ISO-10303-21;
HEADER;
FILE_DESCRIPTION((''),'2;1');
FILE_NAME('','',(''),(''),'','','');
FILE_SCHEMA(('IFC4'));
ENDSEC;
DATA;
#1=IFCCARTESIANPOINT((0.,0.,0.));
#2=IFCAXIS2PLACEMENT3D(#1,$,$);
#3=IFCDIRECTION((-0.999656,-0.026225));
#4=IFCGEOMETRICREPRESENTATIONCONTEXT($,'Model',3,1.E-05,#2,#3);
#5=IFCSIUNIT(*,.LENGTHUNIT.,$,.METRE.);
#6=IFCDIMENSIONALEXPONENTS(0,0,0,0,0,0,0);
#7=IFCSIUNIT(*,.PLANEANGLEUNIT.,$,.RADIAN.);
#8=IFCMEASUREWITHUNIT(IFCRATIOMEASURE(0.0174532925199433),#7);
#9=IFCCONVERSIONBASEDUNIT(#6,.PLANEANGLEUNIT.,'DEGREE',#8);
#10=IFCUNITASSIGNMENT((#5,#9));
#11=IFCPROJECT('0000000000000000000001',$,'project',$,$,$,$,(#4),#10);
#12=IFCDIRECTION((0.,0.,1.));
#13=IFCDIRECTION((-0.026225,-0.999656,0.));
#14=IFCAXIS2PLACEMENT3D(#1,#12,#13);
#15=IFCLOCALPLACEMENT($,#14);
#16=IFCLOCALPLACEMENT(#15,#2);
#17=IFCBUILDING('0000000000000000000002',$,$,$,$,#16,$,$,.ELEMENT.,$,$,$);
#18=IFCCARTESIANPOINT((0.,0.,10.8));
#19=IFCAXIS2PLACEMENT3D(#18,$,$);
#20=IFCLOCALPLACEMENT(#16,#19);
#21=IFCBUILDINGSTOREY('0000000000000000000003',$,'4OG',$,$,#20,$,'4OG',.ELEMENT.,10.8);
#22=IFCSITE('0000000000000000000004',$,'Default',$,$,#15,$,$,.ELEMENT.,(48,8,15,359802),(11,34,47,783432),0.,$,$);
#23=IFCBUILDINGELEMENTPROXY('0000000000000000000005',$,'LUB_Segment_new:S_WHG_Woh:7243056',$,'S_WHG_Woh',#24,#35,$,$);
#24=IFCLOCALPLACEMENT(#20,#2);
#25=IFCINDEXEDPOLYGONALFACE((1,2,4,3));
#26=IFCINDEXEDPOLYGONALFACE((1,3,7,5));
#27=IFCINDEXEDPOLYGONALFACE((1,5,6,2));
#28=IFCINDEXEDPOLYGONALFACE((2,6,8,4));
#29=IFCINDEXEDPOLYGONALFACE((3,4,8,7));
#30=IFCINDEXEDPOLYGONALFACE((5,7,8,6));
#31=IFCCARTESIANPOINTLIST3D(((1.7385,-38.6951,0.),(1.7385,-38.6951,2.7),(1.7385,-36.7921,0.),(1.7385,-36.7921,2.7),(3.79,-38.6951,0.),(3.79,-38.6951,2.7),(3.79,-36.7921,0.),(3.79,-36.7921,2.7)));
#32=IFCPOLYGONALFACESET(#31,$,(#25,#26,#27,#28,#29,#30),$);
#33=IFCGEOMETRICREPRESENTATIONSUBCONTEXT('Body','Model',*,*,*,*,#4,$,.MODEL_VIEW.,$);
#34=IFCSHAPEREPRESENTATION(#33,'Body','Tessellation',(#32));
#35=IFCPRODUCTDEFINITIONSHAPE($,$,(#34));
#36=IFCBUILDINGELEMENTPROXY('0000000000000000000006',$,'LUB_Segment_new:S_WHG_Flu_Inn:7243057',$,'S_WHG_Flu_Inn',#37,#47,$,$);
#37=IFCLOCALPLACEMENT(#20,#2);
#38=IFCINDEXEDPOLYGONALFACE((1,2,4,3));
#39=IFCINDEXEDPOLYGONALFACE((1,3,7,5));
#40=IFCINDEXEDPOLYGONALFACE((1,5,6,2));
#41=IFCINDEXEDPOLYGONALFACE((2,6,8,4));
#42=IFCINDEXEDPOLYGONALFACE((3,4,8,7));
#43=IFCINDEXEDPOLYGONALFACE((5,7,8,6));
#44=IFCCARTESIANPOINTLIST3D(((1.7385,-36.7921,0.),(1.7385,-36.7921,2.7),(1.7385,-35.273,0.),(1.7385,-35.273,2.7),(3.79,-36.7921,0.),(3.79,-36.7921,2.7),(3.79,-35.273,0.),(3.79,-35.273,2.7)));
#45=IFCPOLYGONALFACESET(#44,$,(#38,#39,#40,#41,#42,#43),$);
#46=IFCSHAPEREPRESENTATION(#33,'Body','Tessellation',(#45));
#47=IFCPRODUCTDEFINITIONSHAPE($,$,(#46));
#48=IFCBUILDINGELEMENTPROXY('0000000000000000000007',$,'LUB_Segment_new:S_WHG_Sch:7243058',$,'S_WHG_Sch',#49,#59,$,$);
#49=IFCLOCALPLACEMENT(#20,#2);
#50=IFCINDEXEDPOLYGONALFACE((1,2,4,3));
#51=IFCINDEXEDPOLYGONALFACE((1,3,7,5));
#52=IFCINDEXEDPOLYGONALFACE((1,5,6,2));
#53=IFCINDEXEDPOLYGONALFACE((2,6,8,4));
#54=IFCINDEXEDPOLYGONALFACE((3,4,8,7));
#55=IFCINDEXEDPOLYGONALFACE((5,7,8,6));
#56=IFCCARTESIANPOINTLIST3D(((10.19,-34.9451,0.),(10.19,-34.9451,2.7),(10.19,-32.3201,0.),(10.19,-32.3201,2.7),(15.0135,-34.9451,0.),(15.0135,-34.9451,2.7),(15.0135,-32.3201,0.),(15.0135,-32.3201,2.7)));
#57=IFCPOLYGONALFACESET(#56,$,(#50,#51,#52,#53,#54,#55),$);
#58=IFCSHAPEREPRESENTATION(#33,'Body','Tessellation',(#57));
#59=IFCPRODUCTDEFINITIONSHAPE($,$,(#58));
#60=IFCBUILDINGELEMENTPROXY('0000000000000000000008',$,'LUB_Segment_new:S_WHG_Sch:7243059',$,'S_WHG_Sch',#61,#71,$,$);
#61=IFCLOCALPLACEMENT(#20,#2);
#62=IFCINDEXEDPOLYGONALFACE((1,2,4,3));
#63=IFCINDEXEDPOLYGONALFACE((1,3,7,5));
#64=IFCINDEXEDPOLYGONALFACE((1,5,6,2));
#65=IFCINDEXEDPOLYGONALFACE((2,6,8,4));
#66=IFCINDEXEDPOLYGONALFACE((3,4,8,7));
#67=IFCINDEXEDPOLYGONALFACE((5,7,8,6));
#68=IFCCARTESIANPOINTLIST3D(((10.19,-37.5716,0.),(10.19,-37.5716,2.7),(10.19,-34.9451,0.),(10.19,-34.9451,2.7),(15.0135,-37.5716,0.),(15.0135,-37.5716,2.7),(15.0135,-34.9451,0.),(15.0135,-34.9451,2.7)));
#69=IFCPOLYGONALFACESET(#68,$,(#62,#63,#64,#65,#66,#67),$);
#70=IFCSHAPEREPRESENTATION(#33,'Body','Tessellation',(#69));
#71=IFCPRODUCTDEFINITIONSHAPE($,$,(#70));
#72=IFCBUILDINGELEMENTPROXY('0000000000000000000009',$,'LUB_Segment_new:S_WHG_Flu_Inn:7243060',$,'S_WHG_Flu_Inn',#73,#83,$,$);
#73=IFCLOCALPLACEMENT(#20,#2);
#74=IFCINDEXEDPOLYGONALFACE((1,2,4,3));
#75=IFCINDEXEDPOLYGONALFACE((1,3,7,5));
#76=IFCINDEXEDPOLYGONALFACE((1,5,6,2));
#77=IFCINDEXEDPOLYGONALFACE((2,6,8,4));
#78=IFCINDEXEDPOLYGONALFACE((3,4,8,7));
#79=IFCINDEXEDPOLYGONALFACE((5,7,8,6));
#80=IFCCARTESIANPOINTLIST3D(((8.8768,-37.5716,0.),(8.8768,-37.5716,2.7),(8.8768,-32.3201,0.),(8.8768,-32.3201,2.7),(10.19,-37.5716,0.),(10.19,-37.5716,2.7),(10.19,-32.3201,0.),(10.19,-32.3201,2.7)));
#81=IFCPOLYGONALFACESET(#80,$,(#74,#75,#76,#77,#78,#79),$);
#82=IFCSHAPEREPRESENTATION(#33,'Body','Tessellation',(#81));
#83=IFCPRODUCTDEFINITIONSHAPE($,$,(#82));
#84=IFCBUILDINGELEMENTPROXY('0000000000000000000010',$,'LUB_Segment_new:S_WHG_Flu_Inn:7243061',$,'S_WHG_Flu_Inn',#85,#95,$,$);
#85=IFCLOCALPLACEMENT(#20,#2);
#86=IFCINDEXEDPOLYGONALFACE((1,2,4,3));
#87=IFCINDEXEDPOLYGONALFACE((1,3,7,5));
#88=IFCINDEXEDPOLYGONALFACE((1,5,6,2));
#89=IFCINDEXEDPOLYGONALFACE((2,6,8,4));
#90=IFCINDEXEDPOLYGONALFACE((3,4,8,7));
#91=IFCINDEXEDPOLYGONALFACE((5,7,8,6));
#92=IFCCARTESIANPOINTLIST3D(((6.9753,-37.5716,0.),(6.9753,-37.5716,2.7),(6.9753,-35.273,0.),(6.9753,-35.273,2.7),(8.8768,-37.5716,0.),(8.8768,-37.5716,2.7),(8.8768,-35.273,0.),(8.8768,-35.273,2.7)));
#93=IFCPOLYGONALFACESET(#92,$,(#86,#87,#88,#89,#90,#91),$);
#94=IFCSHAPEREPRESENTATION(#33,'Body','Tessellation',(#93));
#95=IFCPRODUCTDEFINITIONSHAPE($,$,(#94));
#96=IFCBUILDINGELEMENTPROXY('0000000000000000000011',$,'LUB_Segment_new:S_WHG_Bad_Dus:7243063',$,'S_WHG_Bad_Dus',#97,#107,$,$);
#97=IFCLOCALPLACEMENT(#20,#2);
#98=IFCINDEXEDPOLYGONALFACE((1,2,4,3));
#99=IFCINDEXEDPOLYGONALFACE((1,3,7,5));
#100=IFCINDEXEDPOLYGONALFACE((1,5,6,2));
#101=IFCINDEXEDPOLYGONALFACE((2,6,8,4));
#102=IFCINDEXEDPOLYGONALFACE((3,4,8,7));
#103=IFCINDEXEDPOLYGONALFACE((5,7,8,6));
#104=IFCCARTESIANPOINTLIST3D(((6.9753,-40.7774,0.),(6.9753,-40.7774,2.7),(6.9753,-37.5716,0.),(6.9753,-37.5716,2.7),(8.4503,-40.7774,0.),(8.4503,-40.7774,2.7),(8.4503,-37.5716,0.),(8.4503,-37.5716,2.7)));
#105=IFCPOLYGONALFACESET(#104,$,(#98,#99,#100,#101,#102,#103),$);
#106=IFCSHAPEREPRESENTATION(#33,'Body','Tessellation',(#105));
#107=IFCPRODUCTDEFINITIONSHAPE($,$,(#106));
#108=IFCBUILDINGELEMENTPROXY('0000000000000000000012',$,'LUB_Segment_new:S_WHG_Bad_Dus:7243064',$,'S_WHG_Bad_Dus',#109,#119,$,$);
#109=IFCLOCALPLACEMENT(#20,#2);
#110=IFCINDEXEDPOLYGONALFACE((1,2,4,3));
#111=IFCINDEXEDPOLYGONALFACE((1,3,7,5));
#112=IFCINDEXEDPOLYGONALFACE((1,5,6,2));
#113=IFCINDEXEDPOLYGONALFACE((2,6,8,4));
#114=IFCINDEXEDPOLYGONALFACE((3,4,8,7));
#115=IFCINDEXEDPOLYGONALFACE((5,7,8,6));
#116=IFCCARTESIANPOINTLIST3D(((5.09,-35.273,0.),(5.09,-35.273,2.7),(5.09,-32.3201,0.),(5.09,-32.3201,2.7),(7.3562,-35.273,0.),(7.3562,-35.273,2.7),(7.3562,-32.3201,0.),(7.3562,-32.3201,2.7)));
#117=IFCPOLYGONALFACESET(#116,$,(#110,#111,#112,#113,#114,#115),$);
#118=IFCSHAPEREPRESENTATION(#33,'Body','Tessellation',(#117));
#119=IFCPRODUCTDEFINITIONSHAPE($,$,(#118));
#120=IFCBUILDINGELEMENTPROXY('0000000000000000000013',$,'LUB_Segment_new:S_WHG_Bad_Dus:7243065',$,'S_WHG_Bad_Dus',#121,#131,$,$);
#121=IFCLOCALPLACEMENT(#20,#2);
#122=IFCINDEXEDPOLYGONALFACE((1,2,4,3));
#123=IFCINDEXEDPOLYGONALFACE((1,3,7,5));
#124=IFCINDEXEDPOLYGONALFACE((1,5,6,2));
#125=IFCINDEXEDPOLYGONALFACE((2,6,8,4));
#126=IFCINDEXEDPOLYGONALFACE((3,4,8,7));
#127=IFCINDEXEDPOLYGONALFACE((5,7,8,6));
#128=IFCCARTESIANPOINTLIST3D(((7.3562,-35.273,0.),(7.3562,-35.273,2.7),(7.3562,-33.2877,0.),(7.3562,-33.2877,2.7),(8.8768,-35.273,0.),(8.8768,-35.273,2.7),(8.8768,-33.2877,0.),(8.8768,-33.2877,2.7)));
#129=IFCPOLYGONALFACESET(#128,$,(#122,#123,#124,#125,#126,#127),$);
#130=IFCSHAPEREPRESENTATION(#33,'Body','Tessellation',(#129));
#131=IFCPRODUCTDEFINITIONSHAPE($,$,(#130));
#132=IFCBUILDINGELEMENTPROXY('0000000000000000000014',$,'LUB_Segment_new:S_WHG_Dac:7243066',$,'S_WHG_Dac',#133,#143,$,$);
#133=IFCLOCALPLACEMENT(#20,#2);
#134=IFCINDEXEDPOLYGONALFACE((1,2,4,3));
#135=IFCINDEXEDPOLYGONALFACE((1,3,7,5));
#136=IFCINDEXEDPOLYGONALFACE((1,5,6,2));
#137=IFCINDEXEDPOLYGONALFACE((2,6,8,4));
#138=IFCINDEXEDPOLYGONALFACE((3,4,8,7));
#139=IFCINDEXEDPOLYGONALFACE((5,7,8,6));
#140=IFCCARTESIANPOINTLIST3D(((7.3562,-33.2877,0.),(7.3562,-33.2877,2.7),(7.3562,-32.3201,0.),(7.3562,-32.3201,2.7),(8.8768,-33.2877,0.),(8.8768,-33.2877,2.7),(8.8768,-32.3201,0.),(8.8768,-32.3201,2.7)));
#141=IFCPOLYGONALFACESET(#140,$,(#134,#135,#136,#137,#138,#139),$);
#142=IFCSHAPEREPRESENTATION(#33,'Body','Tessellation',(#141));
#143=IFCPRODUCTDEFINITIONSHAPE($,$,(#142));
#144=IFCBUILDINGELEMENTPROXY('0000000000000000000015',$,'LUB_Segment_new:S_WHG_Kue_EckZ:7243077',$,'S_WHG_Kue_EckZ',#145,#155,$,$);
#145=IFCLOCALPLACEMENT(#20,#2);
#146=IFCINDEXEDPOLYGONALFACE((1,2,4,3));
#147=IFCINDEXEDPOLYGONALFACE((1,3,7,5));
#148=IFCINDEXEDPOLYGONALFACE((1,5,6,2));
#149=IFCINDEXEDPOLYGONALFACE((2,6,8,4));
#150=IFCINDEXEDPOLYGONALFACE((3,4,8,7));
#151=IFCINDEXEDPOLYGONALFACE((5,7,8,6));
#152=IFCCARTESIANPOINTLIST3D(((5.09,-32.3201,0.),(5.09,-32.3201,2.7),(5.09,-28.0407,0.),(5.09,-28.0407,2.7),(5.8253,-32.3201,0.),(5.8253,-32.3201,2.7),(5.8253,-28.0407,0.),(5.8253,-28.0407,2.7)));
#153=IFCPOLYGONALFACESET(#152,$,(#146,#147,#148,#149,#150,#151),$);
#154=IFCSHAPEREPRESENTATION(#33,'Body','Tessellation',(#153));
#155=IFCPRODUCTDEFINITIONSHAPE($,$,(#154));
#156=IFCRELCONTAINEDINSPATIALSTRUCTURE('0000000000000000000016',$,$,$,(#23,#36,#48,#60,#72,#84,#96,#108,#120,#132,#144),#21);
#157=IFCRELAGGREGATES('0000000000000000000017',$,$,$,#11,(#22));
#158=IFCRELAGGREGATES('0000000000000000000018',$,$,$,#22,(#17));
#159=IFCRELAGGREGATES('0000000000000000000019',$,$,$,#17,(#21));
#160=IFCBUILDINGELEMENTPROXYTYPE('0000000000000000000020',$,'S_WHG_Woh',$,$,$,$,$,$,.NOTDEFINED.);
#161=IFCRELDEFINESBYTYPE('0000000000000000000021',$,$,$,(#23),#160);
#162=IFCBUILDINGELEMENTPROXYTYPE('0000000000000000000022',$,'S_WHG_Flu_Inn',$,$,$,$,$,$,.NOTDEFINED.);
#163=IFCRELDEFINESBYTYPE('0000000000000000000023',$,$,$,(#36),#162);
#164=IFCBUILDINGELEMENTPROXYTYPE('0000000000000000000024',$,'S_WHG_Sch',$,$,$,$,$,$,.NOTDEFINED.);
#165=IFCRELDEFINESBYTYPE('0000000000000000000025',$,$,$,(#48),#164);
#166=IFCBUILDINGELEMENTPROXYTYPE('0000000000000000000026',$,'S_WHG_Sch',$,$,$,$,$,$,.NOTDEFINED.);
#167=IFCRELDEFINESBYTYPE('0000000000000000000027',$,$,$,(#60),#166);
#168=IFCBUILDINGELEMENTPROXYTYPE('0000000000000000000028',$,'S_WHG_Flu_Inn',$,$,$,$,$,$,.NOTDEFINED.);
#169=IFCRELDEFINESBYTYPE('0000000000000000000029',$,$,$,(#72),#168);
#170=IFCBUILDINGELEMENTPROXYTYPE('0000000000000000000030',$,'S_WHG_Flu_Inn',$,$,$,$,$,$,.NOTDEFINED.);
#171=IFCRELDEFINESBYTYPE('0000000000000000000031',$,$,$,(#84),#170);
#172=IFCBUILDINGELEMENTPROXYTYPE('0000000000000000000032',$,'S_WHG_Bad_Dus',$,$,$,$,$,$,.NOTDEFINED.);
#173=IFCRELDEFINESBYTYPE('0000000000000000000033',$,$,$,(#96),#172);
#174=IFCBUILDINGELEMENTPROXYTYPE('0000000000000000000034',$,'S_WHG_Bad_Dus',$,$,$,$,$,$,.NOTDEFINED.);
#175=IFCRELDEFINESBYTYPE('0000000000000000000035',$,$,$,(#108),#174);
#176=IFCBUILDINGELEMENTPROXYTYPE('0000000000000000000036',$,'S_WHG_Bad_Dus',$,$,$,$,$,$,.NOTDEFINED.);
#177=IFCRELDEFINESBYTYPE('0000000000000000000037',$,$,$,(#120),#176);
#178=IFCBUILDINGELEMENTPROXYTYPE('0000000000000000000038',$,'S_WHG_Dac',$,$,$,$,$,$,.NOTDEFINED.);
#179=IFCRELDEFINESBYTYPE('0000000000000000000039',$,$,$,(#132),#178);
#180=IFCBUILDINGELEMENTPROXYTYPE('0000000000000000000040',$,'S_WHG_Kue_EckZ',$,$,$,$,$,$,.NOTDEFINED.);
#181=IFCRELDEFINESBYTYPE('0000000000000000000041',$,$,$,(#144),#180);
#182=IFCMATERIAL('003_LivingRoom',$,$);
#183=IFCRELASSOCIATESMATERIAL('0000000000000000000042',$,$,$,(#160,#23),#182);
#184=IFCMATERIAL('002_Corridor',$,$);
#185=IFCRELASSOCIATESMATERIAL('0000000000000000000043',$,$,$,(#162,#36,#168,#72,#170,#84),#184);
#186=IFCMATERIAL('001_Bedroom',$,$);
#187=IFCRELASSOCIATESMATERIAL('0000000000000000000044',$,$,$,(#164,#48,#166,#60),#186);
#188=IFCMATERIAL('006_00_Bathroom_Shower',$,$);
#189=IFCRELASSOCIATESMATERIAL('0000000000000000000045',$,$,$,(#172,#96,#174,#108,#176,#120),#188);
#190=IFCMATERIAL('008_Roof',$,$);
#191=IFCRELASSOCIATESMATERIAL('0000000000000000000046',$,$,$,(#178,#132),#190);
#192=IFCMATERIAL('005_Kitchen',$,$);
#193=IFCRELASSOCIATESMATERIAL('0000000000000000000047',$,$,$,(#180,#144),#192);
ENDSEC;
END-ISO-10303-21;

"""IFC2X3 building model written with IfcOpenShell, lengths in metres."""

from ifc_helpers import new_model, entity, si_unit, converted_unit, direction, frame, frame_2d, origin, origin_2d_with_axis, place, context, subcontext, project, spatial, rectangle, extrude, source, transform, mapped, material, type_object, type_shapes, element, save


model = new_model("IFC2X3")

# Units and contexts
model_context = context("Model", 3, precision=1e-05, world=origin(), true_north=direction((-0.999656, -0.026225)))
body_context = subcontext(model_context, "Body", "Model", "MODEL_VIEW")
ifc_project = project(units=[si_unit("LENGTHUNIT", "METRE"), converted_unit("PLANEANGLEUNIT", "DEGREE", entity("IfcRatioMeasure", 0.0174532925199433), si_unit("PLANEANGLEUNIT", "RADIAN"), dimensions=[0, 0, 0, 0, 0, 0, 0])], contexts=[model_context])

# Site, building, storey
site_placement = place(None, frame((0.0, 0.0, 0.0), z_axis=(0.0, 0.0, 1.0), x_axis=(-0.026225, -0.999656, 0.0)))
site = spatial("IfcSite", under=ifc_project, at=site_placement, Name="Default", CompositionType="ELEMENT", RefLatitude=(48, 8, 15, 359802), RefLongitude=(11, 34, 47, 783432), RefElevation=0.0)
building_placement = place(site_placement, origin())
building = spatial("IfcBuilding", under=site, at=building_placement, CompositionType="ELEMENT")
storey_placement = place(building_placement, frame((0.0, 0.0, 10.8)))
storey = spatial("IfcBuildingStorey", under=building, at=storey_placement, Name="4OG", LongName="4OG", CompositionType="ELEMENT", Elevation=10.8)

# Building element proxies
ifc_material_1 = material(Name="001_Bedroom")
ifc_material_2 = material(Name="002_Corridor")
ifc_material_3 = material(Name="006_00_Bathroom_Shower")
ifc_material_4 = material(Name="005_Kitchen")
ifc_material_5 = material(Name="003_LivingRoom")
building_element_proxy_type_1 = type_object("IfcBuildingElementProxyType", Name="S_WHG_Woh", PredefinedType="NOTDEFINED", material=ifc_material_5)
shared_shape_1 = source(origin(), body_context, "Body", "SweptSolid", [
    extrude(rectangle(XDim=2.0515, YDim=1.9029, at=origin_2d_with_axis()), frame((0.0, 0.0, 0.0), z_axis=(0.0, 0.0, 1.0), x_axis=(-1.0, 0.0, 0.0)), (0.0, 0.0, 1.0), 2.7),
])
type_shapes(building_element_proxy_type_1, [shared_shape_1])
proxy_1_placement = place(storey_placement, frame((2.7643, -37.7436, 0.0)))
element("IfcBuildingElementProxy", 1, at=proxy_1_placement, inside=storey, type_object=building_element_proxy_type_1, material=ifc_material_5, Name="LUB_Segment_new:S_WHG_Woh:7243056", ObjectType="S_WHG_Woh", context=body_context, shape_type="MappedRepresentation", body=[
    mapped(shared_shape_1, transform((0.0, 0.0, 0.0), scale=1.0)),
])
building_element_proxy_type_2 = type_object("IfcBuildingElementProxyType", Name="S_WHG_Flu_Inn", PredefinedType="NOTDEFINED", material=ifc_material_2)
shared_shape_2 = source(origin(), body_context, "Body", "SweptSolid", [
    extrude(rectangle(XDim=2.0515, YDim=1.5191, at=origin_2d_with_axis()), frame((0.0, 0.0, 0.0), z_axis=(0.0, 0.0, 1.0), x_axis=(-1.0, 0.0, 0.0)), (0.0, 0.0, 1.0), 2.7),
])
type_shapes(building_element_proxy_type_2, [shared_shape_2])
proxy_2_placement = place(storey_placement, frame((2.7643, -36.0326, 0.0)))
element("IfcBuildingElementProxy", 2, at=proxy_2_placement, inside=storey, type_object=building_element_proxy_type_2, material=ifc_material_2, Name="LUB_Segment_new:S_WHG_Flu_Inn:7243057", ObjectType="S_WHG_Flu_Inn", context=body_context, shape_type="MappedRepresentation", body=[
    mapped(shared_shape_2, transform((0.0, 0.0, 0.0), scale=1.0)),
])
building_element_proxy_type_3 = type_object("IfcBuildingElementProxyType", Name="S_WHG_Sch", PredefinedType="NOTDEFINED", material=ifc_material_1)
shared_shape_3 = source(origin(), body_context, "Body", "SweptSolid", [
    extrude(rectangle(XDim=4.8235, YDim=2.625, at=origin_2d_with_axis()), frame((0.0, 0.0, 0.0), z_axis=(0.0, 0.0, 1.0), x_axis=(-1.0, 0.0, 0.0)), (0.0, 0.0, 1.0), 2.7),
])
type_shapes(building_element_proxy_type_3, [shared_shape_3])
proxy_3_placement = place(storey_placement, frame((12.6018, -33.6326, 0.0)))
element("IfcBuildingElementProxy", 3, at=proxy_3_placement, inside=storey, type_object=building_element_proxy_type_3, material=ifc_material_1, Name="LUB_Segment_new:S_WHG_Sch:7243058", ObjectType="S_WHG_Sch", context=body_context, shape_type="MappedRepresentation", body=[
    mapped(shared_shape_3, transform((0.0, 0.0, 0.0), scale=1.0)),
])
building_element_proxy_type_4 = type_object("IfcBuildingElementProxyType", Name="S_WHG_Sch", PredefinedType="NOTDEFINED", material=ifc_material_1)
shared_shape_4 = source(origin(), body_context, "Body", "SweptSolid", [
    extrude(rectangle(XDim=4.8235, YDim=2.6265, at=origin_2d_with_axis()), frame((0.0, 0.0, 0.0), z_axis=(0.0, 0.0, 1.0), x_axis=(-1.0, 0.0, 0.0)), (0.0, 0.0, 1.0), 2.7),
])
type_shapes(building_element_proxy_type_4, [shared_shape_4])
proxy_4_placement = place(storey_placement, frame((12.6018, -36.2583, 0.0)))
element("IfcBuildingElementProxy", 4, at=proxy_4_placement, inside=storey, type_object=building_element_proxy_type_4, material=ifc_material_1, Name="LUB_Segment_new:S_WHG_Sch:7243059", ObjectType="S_WHG_Sch", context=body_context, shape_type="MappedRepresentation", body=[
    mapped(shared_shape_4, transform((0.0, 0.0, 0.0), scale=1.0)),
])
building_element_proxy_type_5 = type_object("IfcBuildingElementProxyType", Name="S_WHG_Flu_Inn", PredefinedType="NOTDEFINED", material=ifc_material_2)
shared_shape_5 = source(origin(), body_context, "Body", "SweptSolid", [
    extrude(rectangle(XDim=1.3132, YDim=5.2515, at=origin_2d_with_axis()), frame((0.0, 0.0, 0.0), z_axis=(0.0, 0.0, 1.0), x_axis=(-1.0, 0.0, 0.0)), (0.0, 0.0, 1.0), 2.7),
])
type_shapes(building_element_proxy_type_5, [shared_shape_5])
proxy_5_placement = place(storey_placement, frame((9.5334, -34.9458, 0.0)))
element("IfcBuildingElementProxy", 5, at=proxy_5_placement, inside=storey, type_object=building_element_proxy_type_5, material=ifc_material_2, Name="LUB_Segment_new:S_WHG_Flu_Inn:7243060", ObjectType="S_WHG_Flu_Inn", context=body_context, shape_type="MappedRepresentation", body=[
    mapped(shared_shape_5, transform((0.0, 0.0, 0.0), scale=1.0)),
])
building_element_proxy_type_6 = type_object("IfcBuildingElementProxyType", Name="S_WHG_Flu_Inn", PredefinedType="NOTDEFINED", material=ifc_material_2)
shared_shape_6 = source(origin(), body_context, "Body", "SweptSolid", [
    extrude(rectangle(XDim=1.9015, YDim=2.2985, at=origin_2d_with_axis()), frame((0.0, 0.0, 0.0), z_axis=(0.0, 0.0, 1.0), x_axis=(-1.0, 0.0, 0.0)), (0.0, 0.0, 1.0), 2.7),
])
type_shapes(building_element_proxy_type_6, [shared_shape_6])
proxy_6_placement = place(storey_placement, frame((7.926, -36.4223, 0.0)))
element("IfcBuildingElementProxy", 6, at=proxy_6_placement, inside=storey, type_object=building_element_proxy_type_6, material=ifc_material_2, Name="LUB_Segment_new:S_WHG_Flu_Inn:7243061", ObjectType="S_WHG_Flu_Inn", context=body_context, shape_type="MappedRepresentation", body=[
    mapped(shared_shape_6, transform((0.0, 0.0, 0.0), scale=1.0)),
])
building_element_proxy_type_7 = type_object("IfcBuildingElementProxyType", Name="S_WHG_Bad_Dus", PredefinedType="NOTDEFINED", material=ifc_material_3)
shared_shape_7 = source(origin(), body_context, "Body", "SweptSolid", [
    extrude(rectangle(XDim=3.2059, YDim=1.475, at=origin_2d_with_axis()), frame((0.0, 0.0, 0.0), z_axis=(0.0, 0.0, 1.0), x_axis=(0.0, 1.0, 0.0)), (0.0, 0.0, 1.0), 2.7),
])
type_shapes(building_element_proxy_type_7, [shared_shape_7])
proxy_7_placement = place(storey_placement, frame((7.7128, -39.1745, 0.0)))
element("IfcBuildingElementProxy", 7, at=proxy_7_placement, inside=storey, type_object=building_element_proxy_type_7, material=ifc_material_3, Name="LUB_Segment_new:S_WHG_Bad_Dus:7243063", ObjectType="S_WHG_Bad_Dus", context=body_context, shape_type="MappedRepresentation", body=[
    mapped(shared_shape_7, transform((0.0, 0.0, 0.0), scale=1.0)),
])
building_element_proxy_type_8 = type_object("IfcBuildingElementProxyType", Name="S_WHG_Bad_Dus", PredefinedType="NOTDEFINED", material=ifc_material_3)
shared_shape_8 = source(origin(), body_context, "Body", "SweptSolid", [
    extrude(rectangle(XDim=2.9529, YDim=2.2662, at=origin_2d_with_axis()), frame((0.0, 0.0, 0.0), z_axis=(0.0, 0.0, 1.0), x_axis=(0.0, 1.0, 0.0)), (0.0, 0.0, 1.0), 2.7),
])
type_shapes(building_element_proxy_type_8, [shared_shape_8])
proxy_8_placement = place(storey_placement, frame((6.2231, -33.7966, 0.0)))
element("IfcBuildingElementProxy", 8, at=proxy_8_placement, inside=storey, type_object=building_element_proxy_type_8, material=ifc_material_3, Name="LUB_Segment_new:S_WHG_Bad_Dus:7243064", ObjectType="S_WHG_Bad_Dus", context=body_context, shape_type="MappedRepresentation", body=[
    mapped(shared_shape_8, transform((0.0, 0.0, 0.0), scale=1.0)),
])
building_element_proxy_type_9 = type_object("IfcBuildingElementProxyType", Name="S_WHG_Bad_Dus", PredefinedType="NOTDEFINED", material=ifc_material_3)
shared_shape_9 = source(origin(), body_context, "Body", "SweptSolid", [
    extrude(rectangle(XDim=1.9853, YDim=1.5206, at=origin_2d_with_axis()), frame((0.0, 0.0, 0.0), z_axis=(0.0, 0.0, 1.0), x_axis=(0.0, 1.0, 0.0)), (0.0, 0.0, 1.0), 2.7),
])
type_shapes(building_element_proxy_type_9, [shared_shape_9])
proxy_9_placement = place(storey_placement, frame((8.1165, -34.2804, 0.0)))
element("IfcBuildingElementProxy", 9, at=proxy_9_placement, inside=storey, type_object=building_element_proxy_type_9, material=ifc_material_3, Name="LUB_Segment_new:S_WHG_Bad_Dus:7243065", ObjectType="S_WHG_Bad_Dus", context=body_context, shape_type="MappedRepresentation", body=[
    mapped(shared_shape_9, transform((0.0, 0.0, 0.0), scale=1.0)),
])
ifc_material_6 = material(Name="008_Roof")
building_element_proxy_type_10 = type_object("IfcBuildingElementProxyType", Name="S_WHG_Dac", PredefinedType="NOTDEFINED", material=ifc_material_6)
shared_shape_10 = source(origin(), body_context, "Body", "SweptSolid", [
    extrude(rectangle(XDim=0.9676, YDim=1.5206, at=frame_2d((0.0, 0.0), x_axis=(1.0, 0.0))), frame((0.0, 0.0, 0.0), z_axis=(0.0, 0.0, 1.0), x_axis=(0.0, 1.0, 0.0)), (0.0, 0.0, 1.0), 2.7),
])
type_shapes(building_element_proxy_type_10, [shared_shape_10])
proxy_10_placement = place(storey_placement, frame((8.1165, -32.8039, 0.0)))
element("IfcBuildingElementProxy", 10, at=proxy_10_placement, inside=storey, type_object=building_element_proxy_type_10, material=ifc_material_6, Name="LUB_Segment_new:S_WHG_Dac:7243066", ObjectType="S_WHG_Dac", context=body_context, shape_type="MappedRepresentation", body=[
    mapped(shared_shape_10, transform((0.0, 0.0, 0.0), scale=1.0)),
])
building_element_proxy_type_11 = type_object("IfcBuildingElementProxyType", Name="S_WHG_Kue_EckZ", PredefinedType="NOTDEFINED", material=ifc_material_4)
shared_shape_11 = source(origin(), body_context, "Body", "SweptSolid", [
    extrude(rectangle(XDim=4.2794, YDim=0.7353, at=origin_2d_with_axis()), frame((0.0, 0.0, 0.0), z_axis=(0.0, 0.0, 1.0), x_axis=(0.0, 1.0, 0.0)), (0.0, 0.0, 1.0), 2.7),
])
type_shapes(building_element_proxy_type_11, [shared_shape_11])
proxy_11_placement = place(storey_placement, frame((5.4577, -30.1804, 0.0)))
element("IfcBuildingElementProxy", 11, at=proxy_11_placement, inside=storey, type_object=building_element_proxy_type_11, material=ifc_material_4, Name="LUB_Segment_new:S_WHG_Kue_EckZ:7243077", ObjectType="S_WHG_Kue_EckZ", context=body_context, shape_type="MappedRepresentation", body=[
    mapped(shared_shape_11, transform((0.0, 0.0, 0.0), scale=1.0)),
])

save(model, "model.ifc")
